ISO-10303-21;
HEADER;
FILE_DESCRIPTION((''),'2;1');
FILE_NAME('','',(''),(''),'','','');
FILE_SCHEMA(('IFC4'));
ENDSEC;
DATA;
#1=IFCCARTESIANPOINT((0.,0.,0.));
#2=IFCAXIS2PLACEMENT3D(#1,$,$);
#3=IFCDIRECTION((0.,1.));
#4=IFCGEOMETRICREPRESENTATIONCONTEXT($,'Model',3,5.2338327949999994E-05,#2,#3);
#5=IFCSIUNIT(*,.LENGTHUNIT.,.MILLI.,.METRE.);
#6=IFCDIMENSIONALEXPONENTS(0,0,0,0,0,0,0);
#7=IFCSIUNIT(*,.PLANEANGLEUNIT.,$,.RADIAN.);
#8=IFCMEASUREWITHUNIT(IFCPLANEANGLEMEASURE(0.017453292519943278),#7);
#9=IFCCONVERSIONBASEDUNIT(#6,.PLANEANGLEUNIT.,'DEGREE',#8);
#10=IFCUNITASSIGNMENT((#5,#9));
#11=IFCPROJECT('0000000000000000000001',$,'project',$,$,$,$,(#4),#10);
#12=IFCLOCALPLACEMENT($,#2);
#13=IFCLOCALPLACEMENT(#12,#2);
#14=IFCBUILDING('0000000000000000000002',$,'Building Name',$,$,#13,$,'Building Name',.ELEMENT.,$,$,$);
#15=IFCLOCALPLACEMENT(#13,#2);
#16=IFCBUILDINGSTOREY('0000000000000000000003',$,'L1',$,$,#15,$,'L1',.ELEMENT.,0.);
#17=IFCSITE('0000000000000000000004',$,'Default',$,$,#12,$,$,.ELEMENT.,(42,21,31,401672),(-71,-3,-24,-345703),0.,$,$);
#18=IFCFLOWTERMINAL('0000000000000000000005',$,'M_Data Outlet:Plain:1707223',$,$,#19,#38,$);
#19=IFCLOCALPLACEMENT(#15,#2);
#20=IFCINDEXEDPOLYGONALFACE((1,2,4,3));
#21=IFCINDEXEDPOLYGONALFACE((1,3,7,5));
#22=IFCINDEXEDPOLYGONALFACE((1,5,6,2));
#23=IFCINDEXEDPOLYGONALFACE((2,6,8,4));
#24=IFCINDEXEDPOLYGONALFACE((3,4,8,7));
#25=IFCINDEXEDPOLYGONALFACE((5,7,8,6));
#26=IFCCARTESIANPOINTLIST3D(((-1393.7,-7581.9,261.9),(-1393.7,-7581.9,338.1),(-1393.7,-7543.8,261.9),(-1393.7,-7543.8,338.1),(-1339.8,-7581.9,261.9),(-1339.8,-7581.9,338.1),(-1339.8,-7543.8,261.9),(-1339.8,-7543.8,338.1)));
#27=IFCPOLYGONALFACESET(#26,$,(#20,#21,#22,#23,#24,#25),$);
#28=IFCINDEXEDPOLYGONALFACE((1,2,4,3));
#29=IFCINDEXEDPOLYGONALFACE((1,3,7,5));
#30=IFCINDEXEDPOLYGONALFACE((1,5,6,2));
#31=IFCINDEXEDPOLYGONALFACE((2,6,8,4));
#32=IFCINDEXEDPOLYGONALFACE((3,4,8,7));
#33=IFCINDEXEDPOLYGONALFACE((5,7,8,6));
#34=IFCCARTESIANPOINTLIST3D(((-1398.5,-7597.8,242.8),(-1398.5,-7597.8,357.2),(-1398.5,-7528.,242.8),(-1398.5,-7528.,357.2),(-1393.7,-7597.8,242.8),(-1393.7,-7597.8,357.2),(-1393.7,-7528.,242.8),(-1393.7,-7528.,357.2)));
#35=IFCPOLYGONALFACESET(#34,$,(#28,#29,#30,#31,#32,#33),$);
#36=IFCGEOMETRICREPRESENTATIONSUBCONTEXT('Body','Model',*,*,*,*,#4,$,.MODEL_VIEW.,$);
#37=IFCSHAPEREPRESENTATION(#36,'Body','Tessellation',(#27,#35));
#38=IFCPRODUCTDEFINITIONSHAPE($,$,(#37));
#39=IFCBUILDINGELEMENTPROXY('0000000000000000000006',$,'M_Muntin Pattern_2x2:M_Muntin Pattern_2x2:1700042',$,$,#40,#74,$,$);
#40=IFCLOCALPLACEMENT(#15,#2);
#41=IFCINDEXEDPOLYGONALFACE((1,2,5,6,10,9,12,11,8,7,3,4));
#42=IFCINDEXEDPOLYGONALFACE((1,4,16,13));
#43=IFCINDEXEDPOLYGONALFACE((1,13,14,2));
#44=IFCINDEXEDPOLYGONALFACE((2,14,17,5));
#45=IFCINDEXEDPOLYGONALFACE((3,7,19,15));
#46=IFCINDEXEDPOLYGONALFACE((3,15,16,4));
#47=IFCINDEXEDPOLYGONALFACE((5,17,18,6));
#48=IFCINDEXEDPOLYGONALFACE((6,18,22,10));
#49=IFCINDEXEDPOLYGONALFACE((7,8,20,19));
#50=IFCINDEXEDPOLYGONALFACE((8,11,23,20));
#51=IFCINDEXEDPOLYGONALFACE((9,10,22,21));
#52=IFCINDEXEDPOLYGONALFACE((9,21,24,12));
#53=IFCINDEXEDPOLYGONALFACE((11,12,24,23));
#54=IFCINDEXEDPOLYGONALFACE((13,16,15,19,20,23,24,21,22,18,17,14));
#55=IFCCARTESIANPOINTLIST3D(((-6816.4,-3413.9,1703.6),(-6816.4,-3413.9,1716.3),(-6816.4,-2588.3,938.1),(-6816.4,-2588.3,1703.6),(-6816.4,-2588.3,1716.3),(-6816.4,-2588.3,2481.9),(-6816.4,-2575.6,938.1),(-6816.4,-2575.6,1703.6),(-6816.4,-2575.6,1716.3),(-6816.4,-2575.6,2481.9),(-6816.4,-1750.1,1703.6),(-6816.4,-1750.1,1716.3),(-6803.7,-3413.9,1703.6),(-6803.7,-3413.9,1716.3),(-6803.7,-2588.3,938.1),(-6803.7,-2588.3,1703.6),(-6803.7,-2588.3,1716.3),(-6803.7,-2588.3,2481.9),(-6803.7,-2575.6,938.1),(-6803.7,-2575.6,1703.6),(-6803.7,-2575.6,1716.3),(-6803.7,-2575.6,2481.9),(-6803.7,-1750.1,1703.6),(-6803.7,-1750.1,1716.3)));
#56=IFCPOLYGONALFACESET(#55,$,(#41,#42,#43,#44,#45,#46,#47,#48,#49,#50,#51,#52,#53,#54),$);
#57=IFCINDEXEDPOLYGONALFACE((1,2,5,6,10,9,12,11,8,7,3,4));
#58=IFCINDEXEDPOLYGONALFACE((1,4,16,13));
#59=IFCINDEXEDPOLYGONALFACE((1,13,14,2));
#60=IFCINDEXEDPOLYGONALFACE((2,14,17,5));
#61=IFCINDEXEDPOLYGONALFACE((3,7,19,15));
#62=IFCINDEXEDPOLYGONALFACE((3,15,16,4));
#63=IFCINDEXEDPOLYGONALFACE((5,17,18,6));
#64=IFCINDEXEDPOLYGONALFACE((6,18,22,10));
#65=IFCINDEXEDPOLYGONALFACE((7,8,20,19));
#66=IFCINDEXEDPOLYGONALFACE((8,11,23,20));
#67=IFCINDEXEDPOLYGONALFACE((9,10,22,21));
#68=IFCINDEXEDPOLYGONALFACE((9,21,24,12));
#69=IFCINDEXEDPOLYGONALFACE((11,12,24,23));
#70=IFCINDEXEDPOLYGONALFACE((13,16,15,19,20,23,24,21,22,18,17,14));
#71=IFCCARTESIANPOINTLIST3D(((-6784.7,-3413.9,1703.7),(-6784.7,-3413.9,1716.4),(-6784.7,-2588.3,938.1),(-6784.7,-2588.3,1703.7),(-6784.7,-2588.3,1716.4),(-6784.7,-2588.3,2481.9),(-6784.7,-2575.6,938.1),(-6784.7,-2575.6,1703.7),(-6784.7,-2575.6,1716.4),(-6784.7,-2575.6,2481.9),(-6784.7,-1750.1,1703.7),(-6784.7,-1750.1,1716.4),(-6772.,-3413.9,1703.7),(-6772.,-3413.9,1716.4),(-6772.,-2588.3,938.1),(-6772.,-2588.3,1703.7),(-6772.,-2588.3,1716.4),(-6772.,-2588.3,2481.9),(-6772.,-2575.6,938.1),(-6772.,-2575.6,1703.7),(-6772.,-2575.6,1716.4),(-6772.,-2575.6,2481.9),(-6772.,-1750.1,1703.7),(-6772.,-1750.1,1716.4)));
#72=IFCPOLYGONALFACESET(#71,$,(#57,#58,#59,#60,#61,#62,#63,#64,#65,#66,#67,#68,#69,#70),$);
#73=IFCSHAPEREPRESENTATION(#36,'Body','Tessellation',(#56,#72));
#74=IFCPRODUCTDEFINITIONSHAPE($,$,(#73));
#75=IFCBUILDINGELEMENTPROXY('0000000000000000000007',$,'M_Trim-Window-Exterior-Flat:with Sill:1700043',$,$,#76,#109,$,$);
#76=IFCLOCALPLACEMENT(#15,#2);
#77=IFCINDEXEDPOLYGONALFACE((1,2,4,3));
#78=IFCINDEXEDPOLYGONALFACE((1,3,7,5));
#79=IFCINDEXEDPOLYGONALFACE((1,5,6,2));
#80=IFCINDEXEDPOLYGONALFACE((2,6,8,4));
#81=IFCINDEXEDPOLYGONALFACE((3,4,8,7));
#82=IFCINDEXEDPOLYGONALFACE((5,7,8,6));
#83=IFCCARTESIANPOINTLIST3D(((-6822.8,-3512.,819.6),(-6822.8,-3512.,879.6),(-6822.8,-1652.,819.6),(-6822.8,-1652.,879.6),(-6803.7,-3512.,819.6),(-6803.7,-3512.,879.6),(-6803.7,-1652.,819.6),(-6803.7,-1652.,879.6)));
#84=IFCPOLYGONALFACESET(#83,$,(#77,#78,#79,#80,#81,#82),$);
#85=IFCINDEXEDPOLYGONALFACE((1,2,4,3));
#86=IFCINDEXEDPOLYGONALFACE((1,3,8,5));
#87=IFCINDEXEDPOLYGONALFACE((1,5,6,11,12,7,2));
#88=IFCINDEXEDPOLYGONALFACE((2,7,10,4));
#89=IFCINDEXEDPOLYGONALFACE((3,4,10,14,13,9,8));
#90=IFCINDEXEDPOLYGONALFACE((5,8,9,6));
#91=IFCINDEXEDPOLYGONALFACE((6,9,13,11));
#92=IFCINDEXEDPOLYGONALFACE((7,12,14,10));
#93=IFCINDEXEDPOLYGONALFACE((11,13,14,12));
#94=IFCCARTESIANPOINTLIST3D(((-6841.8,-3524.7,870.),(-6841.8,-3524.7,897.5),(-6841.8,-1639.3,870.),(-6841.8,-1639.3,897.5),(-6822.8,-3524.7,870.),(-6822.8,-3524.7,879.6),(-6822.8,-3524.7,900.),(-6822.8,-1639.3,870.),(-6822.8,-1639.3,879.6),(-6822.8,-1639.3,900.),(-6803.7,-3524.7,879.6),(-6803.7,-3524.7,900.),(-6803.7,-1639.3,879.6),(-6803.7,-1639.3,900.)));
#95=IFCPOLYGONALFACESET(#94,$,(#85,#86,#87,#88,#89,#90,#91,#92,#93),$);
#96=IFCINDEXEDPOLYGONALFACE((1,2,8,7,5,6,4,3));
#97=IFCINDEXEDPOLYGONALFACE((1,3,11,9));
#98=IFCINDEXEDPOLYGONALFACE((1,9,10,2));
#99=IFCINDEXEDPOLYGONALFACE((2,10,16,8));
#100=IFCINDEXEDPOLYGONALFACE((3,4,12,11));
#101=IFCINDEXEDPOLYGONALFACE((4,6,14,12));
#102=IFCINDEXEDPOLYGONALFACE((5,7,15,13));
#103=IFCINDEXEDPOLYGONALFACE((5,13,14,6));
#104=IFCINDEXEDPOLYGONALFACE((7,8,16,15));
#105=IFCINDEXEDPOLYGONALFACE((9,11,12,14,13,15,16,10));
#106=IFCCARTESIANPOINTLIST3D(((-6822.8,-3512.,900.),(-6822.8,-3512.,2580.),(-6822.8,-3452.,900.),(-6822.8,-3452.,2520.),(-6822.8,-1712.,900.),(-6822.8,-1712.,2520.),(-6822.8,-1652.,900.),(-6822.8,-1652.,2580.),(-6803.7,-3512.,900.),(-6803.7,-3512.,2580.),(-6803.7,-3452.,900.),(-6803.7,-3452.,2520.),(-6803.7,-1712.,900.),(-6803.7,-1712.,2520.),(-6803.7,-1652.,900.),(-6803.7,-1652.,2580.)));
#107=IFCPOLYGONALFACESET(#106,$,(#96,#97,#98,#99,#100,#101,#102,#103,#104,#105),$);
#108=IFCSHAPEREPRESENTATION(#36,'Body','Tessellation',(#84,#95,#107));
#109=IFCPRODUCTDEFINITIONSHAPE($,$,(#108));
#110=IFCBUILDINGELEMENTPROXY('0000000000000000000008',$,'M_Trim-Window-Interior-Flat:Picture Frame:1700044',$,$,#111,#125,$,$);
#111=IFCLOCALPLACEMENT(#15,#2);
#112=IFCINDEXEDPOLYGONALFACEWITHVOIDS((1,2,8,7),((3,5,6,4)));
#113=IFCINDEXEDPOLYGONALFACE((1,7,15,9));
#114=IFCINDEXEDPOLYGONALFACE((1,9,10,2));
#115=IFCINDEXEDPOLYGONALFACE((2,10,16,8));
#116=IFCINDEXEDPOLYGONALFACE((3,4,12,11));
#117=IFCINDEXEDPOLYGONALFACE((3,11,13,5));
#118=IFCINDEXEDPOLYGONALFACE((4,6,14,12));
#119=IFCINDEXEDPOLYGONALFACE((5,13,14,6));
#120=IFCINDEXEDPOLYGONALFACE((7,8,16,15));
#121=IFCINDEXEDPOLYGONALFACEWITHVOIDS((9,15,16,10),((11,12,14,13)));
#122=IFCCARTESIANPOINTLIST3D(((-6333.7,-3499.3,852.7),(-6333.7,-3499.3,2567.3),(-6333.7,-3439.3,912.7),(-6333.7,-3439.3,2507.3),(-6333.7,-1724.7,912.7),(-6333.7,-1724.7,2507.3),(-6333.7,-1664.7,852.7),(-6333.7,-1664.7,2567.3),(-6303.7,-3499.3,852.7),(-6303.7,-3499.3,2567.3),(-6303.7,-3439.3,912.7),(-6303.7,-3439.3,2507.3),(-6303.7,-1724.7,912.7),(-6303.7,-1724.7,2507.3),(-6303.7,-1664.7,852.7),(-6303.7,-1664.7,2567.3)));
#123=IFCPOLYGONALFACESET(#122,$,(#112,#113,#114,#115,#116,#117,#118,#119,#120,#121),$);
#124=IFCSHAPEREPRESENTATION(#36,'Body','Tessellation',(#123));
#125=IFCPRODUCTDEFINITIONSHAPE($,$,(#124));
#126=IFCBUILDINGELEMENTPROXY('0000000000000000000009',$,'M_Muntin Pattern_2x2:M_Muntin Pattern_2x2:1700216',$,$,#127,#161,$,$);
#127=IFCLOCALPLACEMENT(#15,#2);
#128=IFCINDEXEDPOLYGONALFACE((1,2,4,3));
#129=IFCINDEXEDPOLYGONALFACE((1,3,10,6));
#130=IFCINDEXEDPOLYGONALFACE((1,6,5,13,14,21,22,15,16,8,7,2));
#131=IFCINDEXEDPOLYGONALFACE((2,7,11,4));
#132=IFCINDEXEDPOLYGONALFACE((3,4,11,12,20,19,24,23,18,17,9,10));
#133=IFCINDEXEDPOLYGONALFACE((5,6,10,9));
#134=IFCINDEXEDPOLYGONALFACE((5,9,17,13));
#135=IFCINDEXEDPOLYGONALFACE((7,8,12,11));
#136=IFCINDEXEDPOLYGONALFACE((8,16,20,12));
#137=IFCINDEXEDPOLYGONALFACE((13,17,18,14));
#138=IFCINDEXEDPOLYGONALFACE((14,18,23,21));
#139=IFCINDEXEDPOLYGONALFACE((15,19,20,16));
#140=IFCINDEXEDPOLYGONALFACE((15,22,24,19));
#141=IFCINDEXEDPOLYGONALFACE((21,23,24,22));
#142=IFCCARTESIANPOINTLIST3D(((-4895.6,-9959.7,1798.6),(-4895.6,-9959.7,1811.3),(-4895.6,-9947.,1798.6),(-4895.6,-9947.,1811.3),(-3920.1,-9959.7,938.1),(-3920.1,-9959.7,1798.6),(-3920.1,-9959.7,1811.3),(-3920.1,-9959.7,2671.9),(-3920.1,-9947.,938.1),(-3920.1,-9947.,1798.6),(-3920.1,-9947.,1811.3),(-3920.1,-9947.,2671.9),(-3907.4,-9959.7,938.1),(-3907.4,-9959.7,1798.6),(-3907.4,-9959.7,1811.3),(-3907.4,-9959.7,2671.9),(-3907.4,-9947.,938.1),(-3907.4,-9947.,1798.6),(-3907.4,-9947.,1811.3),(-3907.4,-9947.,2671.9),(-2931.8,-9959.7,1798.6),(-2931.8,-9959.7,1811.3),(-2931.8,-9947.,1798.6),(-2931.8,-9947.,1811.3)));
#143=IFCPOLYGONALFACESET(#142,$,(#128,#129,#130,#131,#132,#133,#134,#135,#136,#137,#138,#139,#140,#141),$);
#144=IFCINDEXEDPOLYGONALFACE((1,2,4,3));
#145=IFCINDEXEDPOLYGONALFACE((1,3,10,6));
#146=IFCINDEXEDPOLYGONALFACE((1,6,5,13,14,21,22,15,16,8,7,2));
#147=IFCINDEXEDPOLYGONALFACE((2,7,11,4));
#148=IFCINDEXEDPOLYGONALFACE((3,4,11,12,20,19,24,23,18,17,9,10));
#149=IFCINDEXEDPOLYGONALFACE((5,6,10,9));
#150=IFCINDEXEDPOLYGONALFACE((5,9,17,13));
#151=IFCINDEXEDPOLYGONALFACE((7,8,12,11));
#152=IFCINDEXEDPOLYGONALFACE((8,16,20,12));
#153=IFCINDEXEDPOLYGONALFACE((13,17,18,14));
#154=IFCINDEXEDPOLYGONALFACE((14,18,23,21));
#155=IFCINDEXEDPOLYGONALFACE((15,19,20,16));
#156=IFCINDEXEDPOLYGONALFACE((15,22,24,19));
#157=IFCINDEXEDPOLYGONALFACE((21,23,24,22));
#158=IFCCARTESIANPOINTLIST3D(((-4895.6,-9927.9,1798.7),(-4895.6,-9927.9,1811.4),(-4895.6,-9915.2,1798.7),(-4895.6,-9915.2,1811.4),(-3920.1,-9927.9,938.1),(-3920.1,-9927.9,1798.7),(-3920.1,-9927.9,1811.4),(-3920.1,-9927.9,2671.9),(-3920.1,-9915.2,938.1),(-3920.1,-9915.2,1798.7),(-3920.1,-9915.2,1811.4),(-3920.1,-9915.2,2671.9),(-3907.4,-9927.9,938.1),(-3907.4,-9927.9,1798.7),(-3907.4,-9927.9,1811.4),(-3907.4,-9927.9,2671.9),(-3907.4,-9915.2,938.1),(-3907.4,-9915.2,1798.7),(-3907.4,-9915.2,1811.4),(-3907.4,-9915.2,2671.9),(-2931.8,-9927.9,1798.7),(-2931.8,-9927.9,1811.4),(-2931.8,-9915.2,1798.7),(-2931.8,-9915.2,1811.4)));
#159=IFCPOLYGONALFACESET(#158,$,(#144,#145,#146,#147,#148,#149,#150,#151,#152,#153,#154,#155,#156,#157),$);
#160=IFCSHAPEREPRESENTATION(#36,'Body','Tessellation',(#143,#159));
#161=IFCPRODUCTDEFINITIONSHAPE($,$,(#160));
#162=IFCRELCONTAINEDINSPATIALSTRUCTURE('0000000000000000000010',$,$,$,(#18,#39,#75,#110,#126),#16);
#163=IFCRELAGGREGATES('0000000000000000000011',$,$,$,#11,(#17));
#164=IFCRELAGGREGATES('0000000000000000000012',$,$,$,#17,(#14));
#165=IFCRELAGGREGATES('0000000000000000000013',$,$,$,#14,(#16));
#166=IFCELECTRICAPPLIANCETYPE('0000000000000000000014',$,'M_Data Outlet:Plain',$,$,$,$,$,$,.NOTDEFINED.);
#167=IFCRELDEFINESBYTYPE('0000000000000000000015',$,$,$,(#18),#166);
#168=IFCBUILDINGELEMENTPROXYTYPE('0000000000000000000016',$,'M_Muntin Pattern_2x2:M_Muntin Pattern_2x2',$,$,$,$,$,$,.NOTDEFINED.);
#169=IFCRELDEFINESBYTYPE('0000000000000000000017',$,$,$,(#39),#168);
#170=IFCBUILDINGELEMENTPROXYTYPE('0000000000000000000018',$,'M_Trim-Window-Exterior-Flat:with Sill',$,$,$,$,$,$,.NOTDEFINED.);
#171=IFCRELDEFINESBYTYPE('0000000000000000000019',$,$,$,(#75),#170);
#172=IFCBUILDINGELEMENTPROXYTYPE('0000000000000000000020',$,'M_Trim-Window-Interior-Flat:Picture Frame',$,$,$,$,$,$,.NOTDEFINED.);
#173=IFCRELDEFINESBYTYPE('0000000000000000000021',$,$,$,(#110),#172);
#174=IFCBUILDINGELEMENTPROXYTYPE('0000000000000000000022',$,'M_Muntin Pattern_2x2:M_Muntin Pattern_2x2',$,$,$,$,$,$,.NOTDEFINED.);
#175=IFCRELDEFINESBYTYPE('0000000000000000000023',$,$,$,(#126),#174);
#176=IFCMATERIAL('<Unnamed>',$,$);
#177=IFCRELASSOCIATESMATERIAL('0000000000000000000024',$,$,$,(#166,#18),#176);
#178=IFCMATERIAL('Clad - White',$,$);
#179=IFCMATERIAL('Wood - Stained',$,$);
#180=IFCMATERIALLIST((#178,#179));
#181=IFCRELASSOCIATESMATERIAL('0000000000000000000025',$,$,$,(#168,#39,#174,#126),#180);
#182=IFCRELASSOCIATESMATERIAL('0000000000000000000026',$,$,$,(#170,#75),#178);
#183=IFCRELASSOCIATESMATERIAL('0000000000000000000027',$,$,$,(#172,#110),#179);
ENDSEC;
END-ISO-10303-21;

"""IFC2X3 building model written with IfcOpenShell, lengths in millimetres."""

from ifc_helpers import new_model, entity, si_unit, converted_unit, direction, frame, frame_2d, origin, origin_2d_with_axis, place, context, subcontext, project, spatial, polyline, rectangle, outline, extrude, source, transform, mapped, material, material_list, type_object, type_shapes, element, save


model = new_model("IFC2X3")

# Units and contexts
model_context = context("Model", 3, precision=5.2338327949999994e-05, world=origin(), true_north=direction((0.0, 1.0)))
body_context = subcontext(model_context, "Body", "Model", "MODEL_VIEW")
ifc_project = project(units=[si_unit("LENGTHUNIT", "METRE", prefix="MILLI"), converted_unit("PLANEANGLEUNIT", "DEGREE", entity("IfcPlaneAngleMeasure", 0.017453292519943278), si_unit("PLANEANGLEUNIT", "RADIAN"), dimensions=[0, 0, 0, 0, 0, 0, 0])], contexts=[model_context])

# Site, building, storey
site_placement = place(None, origin())
site = spatial("IfcSite", under=ifc_project, at=site_placement, Name="Default", CompositionType="ELEMENT", RefLatitude=(42, 21, 31, 401672), RefLongitude=(-71, -3, -24, -345703), RefElevation=0.0)
building_placement = place(site_placement, origin())
building = spatial("IfcBuilding", under=site, at=building_placement, Name="Building Name", LongName="Building Name", CompositionType="ELEMENT")
storey_placement = place(building_placement, origin())
storey = spatial("IfcBuildingStorey", under=building, at=storey_placement, Name="L1", LongName="L1", CompositionType="ELEMENT", Elevation=0.0)

# Flow terminal
ifc_material_1 = material(Name="<Unnamed>")
electric_appliance_type = type_object("IfcElectricApplianceType", Name="M_Data Outlet:Plain", PredefinedType="NOTDEFINED", material=ifc_material_1)
shared_shape_1 = source(origin(), body_context, "Body", "SweptSolid", [
    extrude(rectangle(XDim=38.1, YDim=76.2, at=frame_2d((0.0, 0.0), x_axis=(1.0, 0.0))), frame((0.0, 0.0, -54.0), z_axis=(0.0, 0.0, 1.0), x_axis=(-1.0, 0.0, 0.0)), (0.0, 0.0, 1.0), 54.0),
    extrude(rectangle(XDim=69.9, YDim=114.3, at=frame_2d((0.0, 0.0), x_axis=(1.0, 0.0))), frame((0.0, 0.0, 0.0), z_axis=(0.0, 0.0, 1.0), x_axis=(-1.0, 0.0, 0.0)), (0.0, 0.0, 1.0), 4.8),
])
type_shapes(electric_appliance_type, [shared_shape_1])
flow_terminal_placement = place(storey_placement, frame((-1393.7, -7562.9, 300.0), z_axis=(-1.0, 0.0, 0.0), x_axis=(0.0, -1.0, 0.0)))
element("IfcFlowTerminal", 1, at=flow_terminal_placement, inside=storey, type_object=electric_appliance_type, material=ifc_material_1, Name="M_Data Outlet:Plain:1707223", context=body_context, shape_type="MappedRepresentation", body=[
    mapped(shared_shape_1, transform((0.0, 0.0, 0.0), scale=1.0)),
])

# Building element proxies
ifc_material_2 = material(Name="Clad - White")
ifc_material_3 = material(Name="Wood - Stained")
ifc_material_list = material_list([ifc_material_2, ifc_material_3])
building_element_proxy_type_1 = type_object("IfcBuildingElementProxyType", Name="M_Muntin Pattern_2x2:M_Muntin Pattern_2x2", PredefinedType="NOTDEFINED", material=ifc_material_list)
shared_shape_2 = source(origin(), body_context, "Body", "SweptSolid", [
    extrude(outline(polyline([(6.4, -6.4), (771.9, -6.4), (771.9, 6.3), (6.4, 6.3), (6.4, 831.9), (-6.3, 831.9), (-6.3, 6.3), (-771.9, 6.3), (-771.9, -6.4), (-6.3, -6.4), (-6.3, -831.9), (6.4, -831.9), (6.4, -6.4)])), frame((0.0, -22.2, 771.9), z_axis=(0.0, 1.0, 0.0), x_axis=(0.0, 0.0, 1.0)), (0.0, 0.0, 1.0), 12.7),
    extrude(outline(polyline([(6.4, -6.4), (771.9, -6.4), (771.9, 6.3), (6.4, 6.3), (6.4, 831.9), (-6.3, 831.9), (-6.3, 6.3), (-771.9, 6.3), (-771.9, -6.4), (-6.3, -6.4), (-6.3, -831.9), (6.4, -831.9), (6.4, -6.4)])), frame((0.0, 9.5, 771.9), z_axis=(0.0, 1.0, 0.0), x_axis=(0.0, 0.0, 1.0)), (0.0, 0.0, 1.0), 12.7),
])
type_shapes(building_element_proxy_type_1, [shared_shape_2])
proxy_1_placement = place(storey_placement, frame((-6794.2, -2582.0, 938.1), z_axis=(0.0, 0.0, 1.0), x_axis=(0.0, -1.0, 0.0)))
element("IfcBuildingElementProxy", 2, at=proxy_1_placement, inside=storey, type_object=building_element_proxy_type_1, material=ifc_material_list, Name="M_Muntin Pattern_2x2:M_Muntin Pattern_2x2:1700042", context=body_context, shape_type="MappedRepresentation", body=[
    mapped(shared_shape_2, transform((0.0, 0.0, 0.0), scale=1.0)),
])
building_element_proxy_type_2 = type_object("IfcBuildingElementProxyType", Name="M_Trim-Window-Exterior-Flat:with Sill", PredefinedType="NOTDEFINED", material=ifc_material_2)
shared_shape_3 = source(origin(), body_context, "Body", "SweptSolid", [
    extrude(rectangle(XDim=1860.0, YDim=60.0, at=origin_2d_with_axis()), frame((0.0, -1670.4, 0.0), z_axis=(0.0, 0.0, 1.0), x_axis=(-1.0, 0.0, 0.0)), (0.0, 0.0, 1.0), 19.0),
    extrude(outline(polyline([(-19.0, -15.2), (0.0, -15.2), (0.0, -5.7), (19.0, -5.7), (19.0, 14.8), (0.0, 14.8), (-19.0, 12.3), (-19.0, -15.2)])), frame((-942.7, -1634.8, 19.0), z_axis=(1.0, 0.0, 0.0), x_axis=(0.0, 0.0, -1.0)), (0.0, 0.0, 1.0), 1885.4),
    extrude(outline(polyline([(-855.0, -930.0), (825.0, -930.0), (825.0, -870.0), (-795.0, -870.0), (-795.0, 870.0), (825.0, 870.0), (825.0, 930.0), (-855.0, 930.0), (-855.0, -930.0)])), frame((0.0, -795.0, 0.0), z_axis=(0.0, 0.0, 1.0), x_axis=(0.0, -1.0, 0.0)), (0.0, 0.0, 1.0), 19.0),
])
type_shapes(building_element_proxy_type_2, [shared_shape_3])
proxy_2_placement = place(storey_placement, frame((-6803.7, -2582.0, 2520.0), z_axis=(-1.0, 0.0, 0.0), x_axis=(0.0, -1.0, 0.0)))
element("IfcBuildingElementProxy", 3, at=proxy_2_placement, inside=storey, type_object=building_element_proxy_type_2, material=ifc_material_2, Name="M_Trim-Window-Exterior-Flat:with Sill:1700043", context=body_context, shape_type="MappedRepresentation", body=[
    mapped(shared_shape_3, transform((0.0, 0.0, 0.0), scale=1.0)),
])
building_element_proxy_type_3 = type_object("IfcBuildingElementProxyType", Name="M_Trim-Window-Interior-Flat:Picture Frame", PredefinedType="NOTDEFINED", material=ifc_material_3)
shared_shape_4 = source(origin(), body_context, "Body", "SweptSolid", [
    extrude(outline(polyline([(-917.3, -857.3), (917.3, -857.3), (917.3, 857.3), (-917.3, 857.3), (-917.3, -857.3)]), holes=[polyline([(-857.3, -797.3), (-857.3, 797.3), (857.3, 797.3), (857.3, -797.3), (-857.3, -797.3)])]), frame((0.0, -810.0, 0.0), z_axis=(0.0, 0.0, 1.0), x_axis=(-1.0, 0.0, 0.0)), (0.0, 0.0, 1.0), 30.0),
])
type_shapes(building_element_proxy_type_3, [shared_shape_4])
proxy_3_placement = place(storey_placement, frame((-6333.7, -2582.0, 2520.0), z_axis=(1.0, 0.0, 0.0), x_axis=(0.0, 1.0, 0.0)))
element("IfcBuildingElementProxy", 4, at=proxy_3_placement, inside=storey, type_object=building_element_proxy_type_3, material=ifc_material_3, Name="M_Trim-Window-Interior-Flat:Picture Frame:1700044", context=body_context, shape_type="MappedRepresentation", body=[
    mapped(shared_shape_4, transform((0.0, 0.0, 0.0), scale=1.0)),
])
building_element_proxy_type_4 = type_object("IfcBuildingElementProxyType", Name="M_Muntin Pattern_2x2:M_Muntin Pattern_2x2", PredefinedType="NOTDEFINED", material=ifc_material_list)
shared_shape_5 = source(origin(), body_context, "Body", "SweptSolid", [
    extrude(outline(polyline([(6.4, -6.4), (866.9, -6.4), (866.9, 6.3), (6.4, 6.3), (6.4, 981.9), (-6.3, 981.9), (-6.3, 6.3), (-866.9, 6.3), (-866.9, -6.4), (-6.3, -6.4), (-6.3, -981.9), (6.4, -981.9), (6.4, -6.4)])), frame((0.0, -22.2, 866.9), z_axis=(0.0, 1.0, 0.0), x_axis=(0.0, 0.0, 1.0)), (0.0, 0.0, 1.0), 12.7),
    extrude(outline(polyline([(6.4, -6.4), (866.9, -6.4), (866.9, 6.3), (6.4, 6.3), (6.4, 981.9), (-6.3, 981.9), (-6.3, 6.3), (-866.9, 6.3), (-866.9, -6.4), (-6.3, -6.4), (-6.3, -981.9), (6.4, -981.9), (6.4, -6.4)])), frame((0.0, 9.5, 866.9), z_axis=(0.0, 1.0, 0.0), x_axis=(0.0, 0.0, 1.0)), (0.0, 0.0, 1.0), 12.7),
])
type_shapes(building_element_proxy_type_4, [shared_shape_5])
proxy_4_placement = place(storey_placement, frame((-3913.7, -9937.4, 938.1)))
element("IfcBuildingElementProxy", 5, at=proxy_4_placement, inside=storey, type_object=building_element_proxy_type_4, material=ifc_material_list, Name="M_Muntin Pattern_2x2:M_Muntin Pattern_2x2:1700216", context=body_context, shape_type="MappedRepresentation", body=[
    mapped(shared_shape_5, transform((0.0, 0.0, 0.0), scale=1.0)),
])

save(model, "model.ifc")
